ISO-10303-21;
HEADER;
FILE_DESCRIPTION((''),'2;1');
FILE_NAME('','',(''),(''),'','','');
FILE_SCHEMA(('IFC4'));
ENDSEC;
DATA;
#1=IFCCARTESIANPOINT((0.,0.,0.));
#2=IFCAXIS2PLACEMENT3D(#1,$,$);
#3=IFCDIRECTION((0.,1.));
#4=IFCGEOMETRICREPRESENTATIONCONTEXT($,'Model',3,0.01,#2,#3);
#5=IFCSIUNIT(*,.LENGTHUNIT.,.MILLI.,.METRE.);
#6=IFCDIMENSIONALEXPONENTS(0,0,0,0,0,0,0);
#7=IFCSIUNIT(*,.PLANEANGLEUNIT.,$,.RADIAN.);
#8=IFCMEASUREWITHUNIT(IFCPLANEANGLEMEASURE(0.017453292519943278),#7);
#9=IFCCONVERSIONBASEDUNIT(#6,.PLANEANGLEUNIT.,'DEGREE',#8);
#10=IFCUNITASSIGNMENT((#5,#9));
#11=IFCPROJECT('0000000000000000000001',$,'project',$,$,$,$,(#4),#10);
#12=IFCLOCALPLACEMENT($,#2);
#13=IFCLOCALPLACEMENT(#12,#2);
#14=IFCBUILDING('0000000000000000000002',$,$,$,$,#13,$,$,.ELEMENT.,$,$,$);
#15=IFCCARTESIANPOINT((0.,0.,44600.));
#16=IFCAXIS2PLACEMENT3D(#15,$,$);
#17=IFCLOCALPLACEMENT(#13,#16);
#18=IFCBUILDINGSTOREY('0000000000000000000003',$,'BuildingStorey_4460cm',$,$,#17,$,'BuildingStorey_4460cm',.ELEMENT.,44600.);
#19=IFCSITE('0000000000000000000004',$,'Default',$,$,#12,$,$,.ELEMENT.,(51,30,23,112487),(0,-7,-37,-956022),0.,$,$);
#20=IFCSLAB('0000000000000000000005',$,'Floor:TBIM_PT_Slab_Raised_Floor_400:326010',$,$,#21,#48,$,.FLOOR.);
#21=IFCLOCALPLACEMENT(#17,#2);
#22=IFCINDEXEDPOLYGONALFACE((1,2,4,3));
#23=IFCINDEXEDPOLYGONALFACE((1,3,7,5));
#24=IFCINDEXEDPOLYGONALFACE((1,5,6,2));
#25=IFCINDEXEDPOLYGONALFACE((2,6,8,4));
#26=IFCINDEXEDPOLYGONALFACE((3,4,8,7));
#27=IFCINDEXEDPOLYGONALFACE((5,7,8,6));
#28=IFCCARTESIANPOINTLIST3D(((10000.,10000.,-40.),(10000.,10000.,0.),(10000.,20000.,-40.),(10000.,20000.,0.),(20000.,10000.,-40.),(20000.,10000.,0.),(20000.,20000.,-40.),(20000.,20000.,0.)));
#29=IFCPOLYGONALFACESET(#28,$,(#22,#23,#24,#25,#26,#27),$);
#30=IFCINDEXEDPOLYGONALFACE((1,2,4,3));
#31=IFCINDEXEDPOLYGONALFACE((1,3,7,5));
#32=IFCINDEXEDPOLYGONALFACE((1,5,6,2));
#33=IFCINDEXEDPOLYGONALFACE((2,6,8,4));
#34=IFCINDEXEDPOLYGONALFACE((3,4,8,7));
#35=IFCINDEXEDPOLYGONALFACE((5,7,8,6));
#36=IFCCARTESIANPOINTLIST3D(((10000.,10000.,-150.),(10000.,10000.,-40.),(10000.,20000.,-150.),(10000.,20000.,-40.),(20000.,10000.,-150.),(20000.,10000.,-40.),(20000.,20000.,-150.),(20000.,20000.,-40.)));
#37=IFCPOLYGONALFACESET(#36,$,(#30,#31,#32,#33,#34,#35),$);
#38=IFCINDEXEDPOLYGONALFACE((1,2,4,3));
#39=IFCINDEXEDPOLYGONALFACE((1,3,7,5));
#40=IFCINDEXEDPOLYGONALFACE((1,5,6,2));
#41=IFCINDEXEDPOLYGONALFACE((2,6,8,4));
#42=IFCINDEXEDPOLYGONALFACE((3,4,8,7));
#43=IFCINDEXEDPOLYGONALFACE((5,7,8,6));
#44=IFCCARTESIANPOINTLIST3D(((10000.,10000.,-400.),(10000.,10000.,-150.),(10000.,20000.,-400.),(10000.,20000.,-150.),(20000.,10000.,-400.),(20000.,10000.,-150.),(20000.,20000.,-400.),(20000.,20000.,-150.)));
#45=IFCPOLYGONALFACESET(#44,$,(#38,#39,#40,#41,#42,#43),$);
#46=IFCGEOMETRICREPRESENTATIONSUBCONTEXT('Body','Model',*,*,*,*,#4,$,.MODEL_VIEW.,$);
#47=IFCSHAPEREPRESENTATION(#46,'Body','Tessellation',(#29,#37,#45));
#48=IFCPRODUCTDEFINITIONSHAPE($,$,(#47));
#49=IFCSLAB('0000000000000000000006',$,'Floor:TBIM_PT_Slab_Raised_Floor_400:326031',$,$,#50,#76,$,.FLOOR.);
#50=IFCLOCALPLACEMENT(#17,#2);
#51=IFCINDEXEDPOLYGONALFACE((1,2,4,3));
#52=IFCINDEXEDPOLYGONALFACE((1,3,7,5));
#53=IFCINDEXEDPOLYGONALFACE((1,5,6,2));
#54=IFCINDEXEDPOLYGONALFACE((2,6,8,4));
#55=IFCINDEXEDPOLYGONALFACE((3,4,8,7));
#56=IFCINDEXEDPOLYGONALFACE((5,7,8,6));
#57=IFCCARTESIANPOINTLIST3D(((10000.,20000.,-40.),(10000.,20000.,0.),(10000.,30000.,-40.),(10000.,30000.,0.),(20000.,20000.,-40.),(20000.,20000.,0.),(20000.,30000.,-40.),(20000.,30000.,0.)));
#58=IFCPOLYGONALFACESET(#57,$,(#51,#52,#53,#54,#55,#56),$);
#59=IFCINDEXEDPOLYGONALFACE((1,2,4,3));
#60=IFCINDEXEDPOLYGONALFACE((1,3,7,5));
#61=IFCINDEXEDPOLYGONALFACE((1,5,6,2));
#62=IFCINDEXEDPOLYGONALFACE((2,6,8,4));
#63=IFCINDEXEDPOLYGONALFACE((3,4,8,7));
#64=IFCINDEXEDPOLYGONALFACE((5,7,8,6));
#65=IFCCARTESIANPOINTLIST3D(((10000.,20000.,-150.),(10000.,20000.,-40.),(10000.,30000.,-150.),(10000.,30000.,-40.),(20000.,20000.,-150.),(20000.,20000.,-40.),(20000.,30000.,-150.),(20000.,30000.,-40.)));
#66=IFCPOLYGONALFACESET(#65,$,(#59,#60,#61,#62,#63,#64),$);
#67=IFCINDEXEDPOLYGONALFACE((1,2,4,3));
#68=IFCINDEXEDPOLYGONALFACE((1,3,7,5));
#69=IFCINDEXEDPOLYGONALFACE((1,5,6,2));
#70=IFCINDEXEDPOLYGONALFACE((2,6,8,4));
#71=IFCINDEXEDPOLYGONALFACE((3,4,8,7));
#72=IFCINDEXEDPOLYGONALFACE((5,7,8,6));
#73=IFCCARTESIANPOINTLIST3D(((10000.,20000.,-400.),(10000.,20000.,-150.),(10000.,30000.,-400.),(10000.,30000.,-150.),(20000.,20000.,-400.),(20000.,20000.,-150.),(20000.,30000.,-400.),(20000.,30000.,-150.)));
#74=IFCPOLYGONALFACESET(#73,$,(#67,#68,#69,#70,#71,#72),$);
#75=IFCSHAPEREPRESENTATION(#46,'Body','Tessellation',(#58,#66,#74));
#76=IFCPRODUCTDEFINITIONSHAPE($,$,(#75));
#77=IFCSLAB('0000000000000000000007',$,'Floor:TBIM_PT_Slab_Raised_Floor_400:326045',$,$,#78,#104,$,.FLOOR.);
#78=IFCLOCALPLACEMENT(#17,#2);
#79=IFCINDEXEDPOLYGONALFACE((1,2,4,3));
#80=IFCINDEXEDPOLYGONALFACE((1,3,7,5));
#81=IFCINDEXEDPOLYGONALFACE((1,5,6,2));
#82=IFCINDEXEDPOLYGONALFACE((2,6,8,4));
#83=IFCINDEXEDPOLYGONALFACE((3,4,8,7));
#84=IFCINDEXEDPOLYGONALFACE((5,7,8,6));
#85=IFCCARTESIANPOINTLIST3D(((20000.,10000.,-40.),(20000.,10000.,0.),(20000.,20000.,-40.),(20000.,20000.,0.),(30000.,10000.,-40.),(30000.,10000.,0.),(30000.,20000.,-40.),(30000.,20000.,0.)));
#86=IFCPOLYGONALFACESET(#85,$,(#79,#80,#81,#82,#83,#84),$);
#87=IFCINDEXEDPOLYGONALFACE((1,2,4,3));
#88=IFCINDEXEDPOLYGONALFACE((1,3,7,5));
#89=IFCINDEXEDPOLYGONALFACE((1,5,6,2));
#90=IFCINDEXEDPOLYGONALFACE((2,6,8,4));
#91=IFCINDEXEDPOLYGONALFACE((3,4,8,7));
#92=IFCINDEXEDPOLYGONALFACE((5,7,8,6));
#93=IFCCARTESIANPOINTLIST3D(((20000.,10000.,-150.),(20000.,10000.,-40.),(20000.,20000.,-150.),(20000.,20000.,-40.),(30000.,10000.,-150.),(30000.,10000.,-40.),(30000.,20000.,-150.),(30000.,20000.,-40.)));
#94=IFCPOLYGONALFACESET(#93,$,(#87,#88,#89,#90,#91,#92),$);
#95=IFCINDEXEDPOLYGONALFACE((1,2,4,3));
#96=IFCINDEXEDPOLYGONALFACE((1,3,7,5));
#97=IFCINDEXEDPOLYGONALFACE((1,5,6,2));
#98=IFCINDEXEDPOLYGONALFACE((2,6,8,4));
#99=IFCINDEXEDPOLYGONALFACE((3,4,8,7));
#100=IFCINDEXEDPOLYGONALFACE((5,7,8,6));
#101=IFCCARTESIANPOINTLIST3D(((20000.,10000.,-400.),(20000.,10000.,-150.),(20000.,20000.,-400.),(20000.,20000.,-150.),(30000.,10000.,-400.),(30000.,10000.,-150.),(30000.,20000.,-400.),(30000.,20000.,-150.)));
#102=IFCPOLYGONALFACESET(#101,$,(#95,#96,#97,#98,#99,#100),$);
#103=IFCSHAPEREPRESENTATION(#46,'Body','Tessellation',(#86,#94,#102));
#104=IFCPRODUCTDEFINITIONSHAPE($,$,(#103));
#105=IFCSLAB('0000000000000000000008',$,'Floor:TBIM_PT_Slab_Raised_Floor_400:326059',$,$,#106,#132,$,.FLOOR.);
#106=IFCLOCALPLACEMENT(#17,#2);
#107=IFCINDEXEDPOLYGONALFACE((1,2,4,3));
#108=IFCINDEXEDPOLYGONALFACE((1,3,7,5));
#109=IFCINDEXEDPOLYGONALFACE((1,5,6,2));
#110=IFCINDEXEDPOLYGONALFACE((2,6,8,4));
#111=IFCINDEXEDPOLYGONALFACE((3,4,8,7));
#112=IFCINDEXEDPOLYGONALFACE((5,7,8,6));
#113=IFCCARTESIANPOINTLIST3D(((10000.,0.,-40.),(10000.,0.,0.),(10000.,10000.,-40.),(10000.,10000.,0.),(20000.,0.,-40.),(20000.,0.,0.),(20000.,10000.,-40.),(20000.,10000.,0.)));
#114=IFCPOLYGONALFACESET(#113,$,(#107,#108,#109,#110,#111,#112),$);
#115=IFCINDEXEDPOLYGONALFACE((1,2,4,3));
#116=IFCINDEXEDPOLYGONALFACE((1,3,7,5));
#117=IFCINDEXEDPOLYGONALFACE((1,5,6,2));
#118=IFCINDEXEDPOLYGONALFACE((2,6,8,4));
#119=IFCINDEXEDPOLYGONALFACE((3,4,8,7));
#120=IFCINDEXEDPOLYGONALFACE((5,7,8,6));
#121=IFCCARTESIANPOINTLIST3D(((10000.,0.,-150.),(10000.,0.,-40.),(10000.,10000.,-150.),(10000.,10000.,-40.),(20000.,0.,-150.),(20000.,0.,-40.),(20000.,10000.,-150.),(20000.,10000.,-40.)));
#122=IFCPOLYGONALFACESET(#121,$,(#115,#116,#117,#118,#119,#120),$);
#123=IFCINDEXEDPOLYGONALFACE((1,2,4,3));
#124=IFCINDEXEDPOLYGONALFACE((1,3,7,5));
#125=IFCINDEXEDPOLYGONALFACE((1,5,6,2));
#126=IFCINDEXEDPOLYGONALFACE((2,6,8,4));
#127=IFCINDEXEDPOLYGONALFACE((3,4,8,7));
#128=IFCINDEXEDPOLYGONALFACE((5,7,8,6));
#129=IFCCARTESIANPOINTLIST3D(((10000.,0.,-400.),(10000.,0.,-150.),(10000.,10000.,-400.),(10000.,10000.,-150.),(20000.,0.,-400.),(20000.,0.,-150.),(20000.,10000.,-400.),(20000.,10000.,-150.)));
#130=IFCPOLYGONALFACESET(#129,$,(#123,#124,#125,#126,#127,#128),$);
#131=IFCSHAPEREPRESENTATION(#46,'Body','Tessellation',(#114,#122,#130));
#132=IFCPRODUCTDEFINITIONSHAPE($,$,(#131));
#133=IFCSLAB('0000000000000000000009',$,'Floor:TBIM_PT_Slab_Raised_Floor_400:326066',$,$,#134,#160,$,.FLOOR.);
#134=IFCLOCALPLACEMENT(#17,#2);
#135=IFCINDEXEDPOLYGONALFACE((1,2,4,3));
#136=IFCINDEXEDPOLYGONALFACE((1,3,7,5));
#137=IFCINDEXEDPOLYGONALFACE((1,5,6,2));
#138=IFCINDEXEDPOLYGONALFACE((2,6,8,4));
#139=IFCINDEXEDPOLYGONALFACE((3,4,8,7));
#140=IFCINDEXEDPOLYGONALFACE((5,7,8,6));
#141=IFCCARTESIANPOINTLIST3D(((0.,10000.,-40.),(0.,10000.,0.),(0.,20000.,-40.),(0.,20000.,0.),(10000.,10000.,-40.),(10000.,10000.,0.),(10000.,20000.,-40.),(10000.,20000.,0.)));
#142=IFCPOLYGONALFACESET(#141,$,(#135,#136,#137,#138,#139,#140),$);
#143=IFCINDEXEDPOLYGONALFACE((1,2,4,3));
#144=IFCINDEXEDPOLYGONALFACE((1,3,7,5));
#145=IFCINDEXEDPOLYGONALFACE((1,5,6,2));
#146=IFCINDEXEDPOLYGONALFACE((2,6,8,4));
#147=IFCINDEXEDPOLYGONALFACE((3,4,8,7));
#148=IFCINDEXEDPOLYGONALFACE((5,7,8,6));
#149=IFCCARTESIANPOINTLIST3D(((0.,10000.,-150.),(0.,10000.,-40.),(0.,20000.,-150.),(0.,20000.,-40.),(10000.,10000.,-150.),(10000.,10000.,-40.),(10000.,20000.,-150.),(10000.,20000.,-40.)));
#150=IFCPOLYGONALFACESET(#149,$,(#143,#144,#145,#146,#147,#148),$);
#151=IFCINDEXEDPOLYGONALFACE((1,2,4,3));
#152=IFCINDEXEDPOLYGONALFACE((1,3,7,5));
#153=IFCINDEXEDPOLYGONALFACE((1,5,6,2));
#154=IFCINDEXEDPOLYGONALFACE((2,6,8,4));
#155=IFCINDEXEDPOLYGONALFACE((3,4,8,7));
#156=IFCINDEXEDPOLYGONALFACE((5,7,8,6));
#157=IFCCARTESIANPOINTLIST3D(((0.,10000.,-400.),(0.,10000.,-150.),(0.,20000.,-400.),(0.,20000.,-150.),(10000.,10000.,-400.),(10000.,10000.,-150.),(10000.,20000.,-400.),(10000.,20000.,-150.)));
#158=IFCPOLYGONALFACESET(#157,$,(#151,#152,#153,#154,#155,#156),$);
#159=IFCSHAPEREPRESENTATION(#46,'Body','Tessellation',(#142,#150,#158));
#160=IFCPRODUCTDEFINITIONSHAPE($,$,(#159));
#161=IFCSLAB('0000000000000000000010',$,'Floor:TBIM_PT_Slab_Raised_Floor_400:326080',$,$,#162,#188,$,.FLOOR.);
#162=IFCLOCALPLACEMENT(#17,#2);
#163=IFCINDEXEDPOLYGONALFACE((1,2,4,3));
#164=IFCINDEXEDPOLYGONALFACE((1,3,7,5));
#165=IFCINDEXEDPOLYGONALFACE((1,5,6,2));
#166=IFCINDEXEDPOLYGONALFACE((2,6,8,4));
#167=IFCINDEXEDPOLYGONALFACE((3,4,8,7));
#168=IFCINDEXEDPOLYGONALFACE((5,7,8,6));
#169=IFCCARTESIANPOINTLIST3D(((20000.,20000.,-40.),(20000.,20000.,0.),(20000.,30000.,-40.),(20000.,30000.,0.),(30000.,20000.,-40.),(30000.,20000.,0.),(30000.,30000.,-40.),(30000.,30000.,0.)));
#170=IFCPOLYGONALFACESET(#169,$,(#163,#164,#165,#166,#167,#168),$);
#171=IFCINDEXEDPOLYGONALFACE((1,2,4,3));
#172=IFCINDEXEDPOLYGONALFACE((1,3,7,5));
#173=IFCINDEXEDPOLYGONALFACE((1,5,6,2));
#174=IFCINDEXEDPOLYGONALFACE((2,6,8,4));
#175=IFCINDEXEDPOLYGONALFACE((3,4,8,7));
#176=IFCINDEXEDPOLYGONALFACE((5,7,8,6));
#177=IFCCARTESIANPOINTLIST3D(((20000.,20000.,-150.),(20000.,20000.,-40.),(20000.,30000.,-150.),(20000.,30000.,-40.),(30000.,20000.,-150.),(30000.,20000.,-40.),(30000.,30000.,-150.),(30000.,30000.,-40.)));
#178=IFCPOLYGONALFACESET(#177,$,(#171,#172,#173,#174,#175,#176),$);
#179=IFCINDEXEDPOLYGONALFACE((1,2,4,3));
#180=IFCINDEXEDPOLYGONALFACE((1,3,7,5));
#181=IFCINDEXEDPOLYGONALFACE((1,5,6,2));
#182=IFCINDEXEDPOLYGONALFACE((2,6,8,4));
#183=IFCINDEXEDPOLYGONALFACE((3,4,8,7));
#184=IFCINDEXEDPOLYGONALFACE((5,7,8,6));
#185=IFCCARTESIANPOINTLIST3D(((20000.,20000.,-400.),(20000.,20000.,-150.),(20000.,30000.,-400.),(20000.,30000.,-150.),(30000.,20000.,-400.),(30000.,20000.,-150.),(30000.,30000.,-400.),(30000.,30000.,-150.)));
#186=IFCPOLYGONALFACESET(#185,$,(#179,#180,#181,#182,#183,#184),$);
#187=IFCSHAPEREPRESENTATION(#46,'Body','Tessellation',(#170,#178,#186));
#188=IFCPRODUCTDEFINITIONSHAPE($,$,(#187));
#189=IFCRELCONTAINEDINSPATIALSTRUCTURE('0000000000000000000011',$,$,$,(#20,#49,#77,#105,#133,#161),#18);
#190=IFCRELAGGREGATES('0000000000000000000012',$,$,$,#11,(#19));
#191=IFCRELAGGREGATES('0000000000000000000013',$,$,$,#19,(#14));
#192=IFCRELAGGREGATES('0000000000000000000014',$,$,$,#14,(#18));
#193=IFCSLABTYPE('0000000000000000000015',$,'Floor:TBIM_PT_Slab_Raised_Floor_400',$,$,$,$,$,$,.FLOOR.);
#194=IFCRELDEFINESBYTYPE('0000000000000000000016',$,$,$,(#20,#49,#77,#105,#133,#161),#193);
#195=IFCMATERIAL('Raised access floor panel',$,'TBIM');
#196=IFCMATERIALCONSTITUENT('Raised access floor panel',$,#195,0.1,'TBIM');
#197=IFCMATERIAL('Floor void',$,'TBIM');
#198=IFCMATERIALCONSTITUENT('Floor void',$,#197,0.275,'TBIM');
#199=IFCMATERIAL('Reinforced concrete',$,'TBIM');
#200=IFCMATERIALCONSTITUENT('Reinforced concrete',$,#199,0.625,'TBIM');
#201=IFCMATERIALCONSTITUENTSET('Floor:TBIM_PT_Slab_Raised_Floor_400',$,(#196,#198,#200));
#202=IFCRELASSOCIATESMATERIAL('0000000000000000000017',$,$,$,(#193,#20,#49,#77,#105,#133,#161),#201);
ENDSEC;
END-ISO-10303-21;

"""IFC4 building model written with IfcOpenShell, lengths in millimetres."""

from ifc_helpers import new_model, entity, si_unit, converted_unit, direction, frame, origin, place, context, subcontext, project, spatial, indexed_curve, outline, extrude, material, constituent, constituent_set, type_object, element, save


model = new_model("IFC4")

# Units and contexts
model_context = context("Model", 3, precision=0.01, world=origin(), true_north=direction((0.0, 1.0)))
body_context = subcontext(model_context, "Body", "Model", "MODEL_VIEW")
ifc_project = project(units=[si_unit("LENGTHUNIT", "METRE", prefix="MILLI"), converted_unit("PLANEANGLEUNIT", "DEGREE", entity("IfcPlaneAngleMeasure", 0.017453292519943278), si_unit("PLANEANGLEUNIT", "RADIAN"), dimensions=[0, 0, 0, 0, 0, 0, 0])], contexts=[model_context])

# Site, building, storey
site_placement = place(None, origin())
site = spatial("IfcSite", under=ifc_project, at=site_placement, Name="Default", CompositionType="ELEMENT", RefLatitude=(51, 30, 23, 112487), RefLongitude=(0, -7, -37, -956022), RefElevation=0.0)
building_placement = place(site_placement, origin())
building = spatial("IfcBuilding", under=site, at=building_placement, CompositionType="ELEMENT")
storey_placement = place(building_placement, frame((0.0, 0.0, 44600.0)))
storey = spatial("IfcBuildingStorey", under=building, at=storey_placement, Name="BuildingStorey_4460cm", LongName="BuildingStorey_4460cm", CompositionType="ELEMENT", Elevation=44600.0)

# Slabs
ifc_material_1 = material(Name="Raised access floor panel", Category="TBIM")
ifc_constituent_1 = constituent(ifc_material_1, Name="Raised access floor panel", Category="TBIM", fraction=0.1)
ifc_material_2 = material(Name="Floor void", Category="TBIM")
ifc_constituent_2 = constituent(ifc_material_2, Name="Floor void", Category="TBIM", fraction=0.275)
ifc_material_3 = material(Name="Reinforced concrete", Category="TBIM")
ifc_constituent_3 = constituent(ifc_material_3, Name="Reinforced concrete", Category="TBIM", fraction=0.625)
ifc_constituent_set_1 = constituent_set(constituents=[ifc_constituent_1, ifc_constituent_2, ifc_constituent_3], Name="Floor:TBIM_PT_Slab_Raised_Floor_400")
slab_type = type_object("IfcSlabType", Name="Floor:TBIM_PT_Slab_Raised_Floor_400", PredefinedType="FLOOR", material=ifc_constituent_set_1)
slab_1_placement = place(storey_placement, origin())
element("IfcSlab", 1, at=slab_1_placement, inside=storey, type_object=slab_type, material=ifc_constituent_set_1, Name="Floor:TBIM_PT_Slab_Raised_Floor_400:326010", PredefinedType="FLOOR", context=body_context, shape_type="SweptSolid", body=[
    extrude(outline(indexed_curve([(-5000.0, -5000.0), (5000.0, -5000.0), (5000.0, 5000.0), (-5000.0, 5000.0), (-5000.0, -5000.0)], self_intersect=False)), frame((15000.0, 15000.0, -40.0), z_axis=(0.0, 0.0, 1.0), x_axis=(-1.0, 0.0, 0.0)), (0.0, 0.0, 1.0), 40.0),
    extrude(outline(indexed_curve([(-5000.0, -5000.0), (5000.0, -5000.0), (5000.0, 5000.0), (-5000.0, 5000.0), (-5000.0, -5000.0)], self_intersect=False)), frame((15000.0, 15000.0, -150.0), z_axis=(0.0, 0.0, 1.0), x_axis=(-1.0, 0.0, 0.0)), (0.0, 0.0, 1.0), 110.0),
    extrude(outline(indexed_curve([(-5000.0, -5000.0), (5000.0, -5000.0), (5000.0, 5000.0), (-5000.0, 5000.0), (-5000.0, -5000.0)], self_intersect=False)), frame((15000.0, 15000.0, -400.0), z_axis=(0.0, 0.0, 1.0), x_axis=(-1.0, 0.0, 0.0)), (0.0, 0.0, 1.0), 250.0),
])
slab_2_placement = place(storey_placement, origin())
element("IfcSlab", 2, at=slab_2_placement, inside=storey, type_object=slab_type, material=ifc_constituent_set_1, Name="Floor:TBIM_PT_Slab_Raised_Floor_400:326031", PredefinedType="FLOOR", context=body_context, shape_type="SweptSolid", body=[
    extrude(outline(indexed_curve([(-5000.0, -5000.0), (5000.0, -5000.0), (5000.0, 5000.0), (-5000.0, 5000.0), (-5000.0, -5000.0)], self_intersect=False)), frame((15000.0, 25000.0, -40.0), z_axis=(0.0, 0.0, 1.0), x_axis=(-1.0, 0.0, 0.0)), (0.0, 0.0, 1.0), 40.0),
    extrude(outline(indexed_curve([(-5000.0, -5000.0), (5000.0, -5000.0), (5000.0, 5000.0), (-5000.0, 5000.0), (-5000.0, -5000.0)], self_intersect=False)), frame((15000.0, 25000.0, -150.0), z_axis=(0.0, 0.0, 1.0), x_axis=(-1.0, 0.0, 0.0)), (0.0, 0.0, 1.0), 110.0),
    extrude(outline(indexed_curve([(-5000.0, -5000.0), (5000.0, -5000.0), (5000.0, 5000.0), (-5000.0, 5000.0), (-5000.0, -5000.0)], self_intersect=False)), frame((15000.0, 25000.0, -400.0), z_axis=(0.0, 0.0, 1.0), x_axis=(-1.0, 0.0, 0.0)), (0.0, 0.0, 1.0), 250.0),
])
slab_3_placement = place(storey_placement, origin())
element("IfcSlab", 3, at=slab_3_placement, inside=storey, type_object=slab_type, material=ifc_constituent_set_1, Name="Floor:TBIM_PT_Slab_Raised_Floor_400:326045", PredefinedType="FLOOR", context=body_context, shape_type="SweptSolid", body=[
    extrude(outline(indexed_curve([(-5000.0, -5000.0), (5000.0, -5000.0), (5000.0, 5000.0), (-5000.0, 5000.0), (-5000.0, -5000.0)], self_intersect=False)), frame((25000.0, 15000.0, -40.0), z_axis=(0.0, 0.0, 1.0), x_axis=(-1.0, 0.0, 0.0)), (0.0, 0.0, 1.0), 40.0),
    extrude(outline(indexed_curve([(-5000.0, -5000.0), (5000.0, -5000.0), (5000.0, 5000.0), (-5000.0, 5000.0), (-5000.0, -5000.0)], self_intersect=False)), frame((25000.0, 15000.0, -150.0), z_axis=(0.0, 0.0, 1.0), x_axis=(-1.0, 0.0, 0.0)), (0.0, 0.0, 1.0), 110.0),
    extrude(outline(indexed_curve([(-5000.0, -5000.0), (5000.0, -5000.0), (5000.0, 5000.0), (-5000.0, 5000.0), (-5000.0, -5000.0)], self_intersect=False)), frame((25000.0, 15000.0, -400.0), z_axis=(0.0, 0.0, 1.0), x_axis=(-1.0, 0.0, 0.0)), (0.0, 0.0, 1.0), 250.0),
])
slab_4_placement = place(storey_placement, origin())
element("IfcSlab", 4, at=slab_4_placement, inside=storey, type_object=slab_type, material=ifc_constituent_set_1, Name="Floor:TBIM_PT_Slab_Raised_Floor_400:326059", PredefinedType="FLOOR", context=body_context, shape_type="SweptSolid", body=[
    extrude(outline(indexed_curve([(-5000.0, -5000.0), (5000.0, -5000.0), (5000.0, 5000.0), (-5000.0, 5000.0), (-5000.0, -5000.0)], self_intersect=False)), frame((15000.0, 5000.0, -40.0), z_axis=(0.0, 0.0, 1.0), x_axis=(0.0, 1.0, 0.0)), (0.0, 0.0, 1.0), 40.0),
    extrude(outline(indexed_curve([(-5000.0, -5000.0), (5000.0, -5000.0), (5000.0, 5000.0), (-5000.0, 5000.0), (-5000.0, -5000.0)], self_intersect=False)), frame((15000.0, 5000.0, -150.0), z_axis=(0.0, 0.0, 1.0), x_axis=(0.0, 1.0, 0.0)), (0.0, 0.0, 1.0), 110.0),
    extrude(outline(indexed_curve([(-5000.0, -5000.0), (5000.0, -5000.0), (5000.0, 5000.0), (-5000.0, 5000.0), (-5000.0, -5000.0)], self_intersect=False)), frame((15000.0, 5000.0, -400.0), z_axis=(0.0, 0.0, 1.0), x_axis=(0.0, 1.0, 0.0)), (0.0, 0.0, 1.0), 250.0),
])
slab_5_placement = place(storey_placement, origin())
element("IfcSlab", 5, at=slab_5_placement, inside=storey, type_object=slab_type, material=ifc_constituent_set_1, Name="Floor:TBIM_PT_Slab_Raised_Floor_400:326066", PredefinedType="FLOOR", context=body_context, shape_type="SweptSolid", body=[
    extrude(outline(indexed_curve([(-5000.0, -5000.0), (5000.0, -5000.0), (5000.0, 5000.0), (-5000.0, 5000.0), (-5000.0, -5000.0)], self_intersect=False)), frame((5000.0, 15000.0, -40.0), z_axis=(0.0, 0.0, 1.0), x_axis=(0.0, 1.0, 0.0)), (0.0, 0.0, 1.0), 40.0),
    extrude(outline(indexed_curve([(-5000.0, -5000.0), (5000.0, -5000.0), (5000.0, 5000.0), (-5000.0, 5000.0), (-5000.0, -5000.0)], self_intersect=False)), frame((5000.0, 15000.0, -150.0), z_axis=(0.0, 0.0, 1.0), x_axis=(0.0, 1.0, 0.0)), (0.0, 0.0, 1.0), 110.0),
    extrude(outline(indexed_curve([(-5000.0, -5000.0), (5000.0, -5000.0), (5000.0, 5000.0), (-5000.0, 5000.0), (-5000.0, -5000.0)], self_intersect=False)), frame((5000.0, 15000.0, -400.0), z_axis=(0.0, 0.0, 1.0), x_axis=(0.0, 1.0, 0.0)), (0.0, 0.0, 1.0), 250.0),
])
slab_6_placement = place(storey_placement, origin())
element("IfcSlab", 6, at=slab_6_placement, inside=storey, type_object=slab_type, material=ifc_constituent_set_1, Name="Floor:TBIM_PT_Slab_Raised_Floor_400:326080", PredefinedType="FLOOR", context=body_context, shape_type="SweptSolid", body=[
    extrude(outline(indexed_curve([(-5000.0, -5000.0), (5000.0, -5000.0), (5000.0, 5000.0), (-5000.0, 5000.0), (-5000.0, -5000.0)], self_intersect=False)), frame((25000.0, 25000.0, -40.0), z_axis=(0.0, 0.0, 1.0), x_axis=(-1.0, 0.0, 0.0)), (0.0, 0.0, 1.0), 40.0),
    extrude(outline(indexed_curve([(-5000.0, -5000.0), (5000.0, -5000.0), (5000.0, 5000.0), (-5000.0, 5000.0), (-5000.0, -5000.0)], self_intersect=False)), frame((25000.0, 25000.0, -150.0), z_axis=(0.0, 0.0, 1.0), x_axis=(-1.0, 0.0, 0.0)), (0.0, 0.0, 1.0), 110.0),
    extrude(outline(indexed_curve([(-5000.0, -5000.0), (5000.0, -5000.0), (5000.0, 5000.0), (-5000.0, 5000.0), (-5000.0, -5000.0)], self_intersect=False)), frame((25000.0, 25000.0, -400.0), z_axis=(0.0, 0.0, 1.0), x_axis=(-1.0, 0.0, 0.0)), (0.0, 0.0, 1.0), 250.0),
])

save(model, "model.ifc")
